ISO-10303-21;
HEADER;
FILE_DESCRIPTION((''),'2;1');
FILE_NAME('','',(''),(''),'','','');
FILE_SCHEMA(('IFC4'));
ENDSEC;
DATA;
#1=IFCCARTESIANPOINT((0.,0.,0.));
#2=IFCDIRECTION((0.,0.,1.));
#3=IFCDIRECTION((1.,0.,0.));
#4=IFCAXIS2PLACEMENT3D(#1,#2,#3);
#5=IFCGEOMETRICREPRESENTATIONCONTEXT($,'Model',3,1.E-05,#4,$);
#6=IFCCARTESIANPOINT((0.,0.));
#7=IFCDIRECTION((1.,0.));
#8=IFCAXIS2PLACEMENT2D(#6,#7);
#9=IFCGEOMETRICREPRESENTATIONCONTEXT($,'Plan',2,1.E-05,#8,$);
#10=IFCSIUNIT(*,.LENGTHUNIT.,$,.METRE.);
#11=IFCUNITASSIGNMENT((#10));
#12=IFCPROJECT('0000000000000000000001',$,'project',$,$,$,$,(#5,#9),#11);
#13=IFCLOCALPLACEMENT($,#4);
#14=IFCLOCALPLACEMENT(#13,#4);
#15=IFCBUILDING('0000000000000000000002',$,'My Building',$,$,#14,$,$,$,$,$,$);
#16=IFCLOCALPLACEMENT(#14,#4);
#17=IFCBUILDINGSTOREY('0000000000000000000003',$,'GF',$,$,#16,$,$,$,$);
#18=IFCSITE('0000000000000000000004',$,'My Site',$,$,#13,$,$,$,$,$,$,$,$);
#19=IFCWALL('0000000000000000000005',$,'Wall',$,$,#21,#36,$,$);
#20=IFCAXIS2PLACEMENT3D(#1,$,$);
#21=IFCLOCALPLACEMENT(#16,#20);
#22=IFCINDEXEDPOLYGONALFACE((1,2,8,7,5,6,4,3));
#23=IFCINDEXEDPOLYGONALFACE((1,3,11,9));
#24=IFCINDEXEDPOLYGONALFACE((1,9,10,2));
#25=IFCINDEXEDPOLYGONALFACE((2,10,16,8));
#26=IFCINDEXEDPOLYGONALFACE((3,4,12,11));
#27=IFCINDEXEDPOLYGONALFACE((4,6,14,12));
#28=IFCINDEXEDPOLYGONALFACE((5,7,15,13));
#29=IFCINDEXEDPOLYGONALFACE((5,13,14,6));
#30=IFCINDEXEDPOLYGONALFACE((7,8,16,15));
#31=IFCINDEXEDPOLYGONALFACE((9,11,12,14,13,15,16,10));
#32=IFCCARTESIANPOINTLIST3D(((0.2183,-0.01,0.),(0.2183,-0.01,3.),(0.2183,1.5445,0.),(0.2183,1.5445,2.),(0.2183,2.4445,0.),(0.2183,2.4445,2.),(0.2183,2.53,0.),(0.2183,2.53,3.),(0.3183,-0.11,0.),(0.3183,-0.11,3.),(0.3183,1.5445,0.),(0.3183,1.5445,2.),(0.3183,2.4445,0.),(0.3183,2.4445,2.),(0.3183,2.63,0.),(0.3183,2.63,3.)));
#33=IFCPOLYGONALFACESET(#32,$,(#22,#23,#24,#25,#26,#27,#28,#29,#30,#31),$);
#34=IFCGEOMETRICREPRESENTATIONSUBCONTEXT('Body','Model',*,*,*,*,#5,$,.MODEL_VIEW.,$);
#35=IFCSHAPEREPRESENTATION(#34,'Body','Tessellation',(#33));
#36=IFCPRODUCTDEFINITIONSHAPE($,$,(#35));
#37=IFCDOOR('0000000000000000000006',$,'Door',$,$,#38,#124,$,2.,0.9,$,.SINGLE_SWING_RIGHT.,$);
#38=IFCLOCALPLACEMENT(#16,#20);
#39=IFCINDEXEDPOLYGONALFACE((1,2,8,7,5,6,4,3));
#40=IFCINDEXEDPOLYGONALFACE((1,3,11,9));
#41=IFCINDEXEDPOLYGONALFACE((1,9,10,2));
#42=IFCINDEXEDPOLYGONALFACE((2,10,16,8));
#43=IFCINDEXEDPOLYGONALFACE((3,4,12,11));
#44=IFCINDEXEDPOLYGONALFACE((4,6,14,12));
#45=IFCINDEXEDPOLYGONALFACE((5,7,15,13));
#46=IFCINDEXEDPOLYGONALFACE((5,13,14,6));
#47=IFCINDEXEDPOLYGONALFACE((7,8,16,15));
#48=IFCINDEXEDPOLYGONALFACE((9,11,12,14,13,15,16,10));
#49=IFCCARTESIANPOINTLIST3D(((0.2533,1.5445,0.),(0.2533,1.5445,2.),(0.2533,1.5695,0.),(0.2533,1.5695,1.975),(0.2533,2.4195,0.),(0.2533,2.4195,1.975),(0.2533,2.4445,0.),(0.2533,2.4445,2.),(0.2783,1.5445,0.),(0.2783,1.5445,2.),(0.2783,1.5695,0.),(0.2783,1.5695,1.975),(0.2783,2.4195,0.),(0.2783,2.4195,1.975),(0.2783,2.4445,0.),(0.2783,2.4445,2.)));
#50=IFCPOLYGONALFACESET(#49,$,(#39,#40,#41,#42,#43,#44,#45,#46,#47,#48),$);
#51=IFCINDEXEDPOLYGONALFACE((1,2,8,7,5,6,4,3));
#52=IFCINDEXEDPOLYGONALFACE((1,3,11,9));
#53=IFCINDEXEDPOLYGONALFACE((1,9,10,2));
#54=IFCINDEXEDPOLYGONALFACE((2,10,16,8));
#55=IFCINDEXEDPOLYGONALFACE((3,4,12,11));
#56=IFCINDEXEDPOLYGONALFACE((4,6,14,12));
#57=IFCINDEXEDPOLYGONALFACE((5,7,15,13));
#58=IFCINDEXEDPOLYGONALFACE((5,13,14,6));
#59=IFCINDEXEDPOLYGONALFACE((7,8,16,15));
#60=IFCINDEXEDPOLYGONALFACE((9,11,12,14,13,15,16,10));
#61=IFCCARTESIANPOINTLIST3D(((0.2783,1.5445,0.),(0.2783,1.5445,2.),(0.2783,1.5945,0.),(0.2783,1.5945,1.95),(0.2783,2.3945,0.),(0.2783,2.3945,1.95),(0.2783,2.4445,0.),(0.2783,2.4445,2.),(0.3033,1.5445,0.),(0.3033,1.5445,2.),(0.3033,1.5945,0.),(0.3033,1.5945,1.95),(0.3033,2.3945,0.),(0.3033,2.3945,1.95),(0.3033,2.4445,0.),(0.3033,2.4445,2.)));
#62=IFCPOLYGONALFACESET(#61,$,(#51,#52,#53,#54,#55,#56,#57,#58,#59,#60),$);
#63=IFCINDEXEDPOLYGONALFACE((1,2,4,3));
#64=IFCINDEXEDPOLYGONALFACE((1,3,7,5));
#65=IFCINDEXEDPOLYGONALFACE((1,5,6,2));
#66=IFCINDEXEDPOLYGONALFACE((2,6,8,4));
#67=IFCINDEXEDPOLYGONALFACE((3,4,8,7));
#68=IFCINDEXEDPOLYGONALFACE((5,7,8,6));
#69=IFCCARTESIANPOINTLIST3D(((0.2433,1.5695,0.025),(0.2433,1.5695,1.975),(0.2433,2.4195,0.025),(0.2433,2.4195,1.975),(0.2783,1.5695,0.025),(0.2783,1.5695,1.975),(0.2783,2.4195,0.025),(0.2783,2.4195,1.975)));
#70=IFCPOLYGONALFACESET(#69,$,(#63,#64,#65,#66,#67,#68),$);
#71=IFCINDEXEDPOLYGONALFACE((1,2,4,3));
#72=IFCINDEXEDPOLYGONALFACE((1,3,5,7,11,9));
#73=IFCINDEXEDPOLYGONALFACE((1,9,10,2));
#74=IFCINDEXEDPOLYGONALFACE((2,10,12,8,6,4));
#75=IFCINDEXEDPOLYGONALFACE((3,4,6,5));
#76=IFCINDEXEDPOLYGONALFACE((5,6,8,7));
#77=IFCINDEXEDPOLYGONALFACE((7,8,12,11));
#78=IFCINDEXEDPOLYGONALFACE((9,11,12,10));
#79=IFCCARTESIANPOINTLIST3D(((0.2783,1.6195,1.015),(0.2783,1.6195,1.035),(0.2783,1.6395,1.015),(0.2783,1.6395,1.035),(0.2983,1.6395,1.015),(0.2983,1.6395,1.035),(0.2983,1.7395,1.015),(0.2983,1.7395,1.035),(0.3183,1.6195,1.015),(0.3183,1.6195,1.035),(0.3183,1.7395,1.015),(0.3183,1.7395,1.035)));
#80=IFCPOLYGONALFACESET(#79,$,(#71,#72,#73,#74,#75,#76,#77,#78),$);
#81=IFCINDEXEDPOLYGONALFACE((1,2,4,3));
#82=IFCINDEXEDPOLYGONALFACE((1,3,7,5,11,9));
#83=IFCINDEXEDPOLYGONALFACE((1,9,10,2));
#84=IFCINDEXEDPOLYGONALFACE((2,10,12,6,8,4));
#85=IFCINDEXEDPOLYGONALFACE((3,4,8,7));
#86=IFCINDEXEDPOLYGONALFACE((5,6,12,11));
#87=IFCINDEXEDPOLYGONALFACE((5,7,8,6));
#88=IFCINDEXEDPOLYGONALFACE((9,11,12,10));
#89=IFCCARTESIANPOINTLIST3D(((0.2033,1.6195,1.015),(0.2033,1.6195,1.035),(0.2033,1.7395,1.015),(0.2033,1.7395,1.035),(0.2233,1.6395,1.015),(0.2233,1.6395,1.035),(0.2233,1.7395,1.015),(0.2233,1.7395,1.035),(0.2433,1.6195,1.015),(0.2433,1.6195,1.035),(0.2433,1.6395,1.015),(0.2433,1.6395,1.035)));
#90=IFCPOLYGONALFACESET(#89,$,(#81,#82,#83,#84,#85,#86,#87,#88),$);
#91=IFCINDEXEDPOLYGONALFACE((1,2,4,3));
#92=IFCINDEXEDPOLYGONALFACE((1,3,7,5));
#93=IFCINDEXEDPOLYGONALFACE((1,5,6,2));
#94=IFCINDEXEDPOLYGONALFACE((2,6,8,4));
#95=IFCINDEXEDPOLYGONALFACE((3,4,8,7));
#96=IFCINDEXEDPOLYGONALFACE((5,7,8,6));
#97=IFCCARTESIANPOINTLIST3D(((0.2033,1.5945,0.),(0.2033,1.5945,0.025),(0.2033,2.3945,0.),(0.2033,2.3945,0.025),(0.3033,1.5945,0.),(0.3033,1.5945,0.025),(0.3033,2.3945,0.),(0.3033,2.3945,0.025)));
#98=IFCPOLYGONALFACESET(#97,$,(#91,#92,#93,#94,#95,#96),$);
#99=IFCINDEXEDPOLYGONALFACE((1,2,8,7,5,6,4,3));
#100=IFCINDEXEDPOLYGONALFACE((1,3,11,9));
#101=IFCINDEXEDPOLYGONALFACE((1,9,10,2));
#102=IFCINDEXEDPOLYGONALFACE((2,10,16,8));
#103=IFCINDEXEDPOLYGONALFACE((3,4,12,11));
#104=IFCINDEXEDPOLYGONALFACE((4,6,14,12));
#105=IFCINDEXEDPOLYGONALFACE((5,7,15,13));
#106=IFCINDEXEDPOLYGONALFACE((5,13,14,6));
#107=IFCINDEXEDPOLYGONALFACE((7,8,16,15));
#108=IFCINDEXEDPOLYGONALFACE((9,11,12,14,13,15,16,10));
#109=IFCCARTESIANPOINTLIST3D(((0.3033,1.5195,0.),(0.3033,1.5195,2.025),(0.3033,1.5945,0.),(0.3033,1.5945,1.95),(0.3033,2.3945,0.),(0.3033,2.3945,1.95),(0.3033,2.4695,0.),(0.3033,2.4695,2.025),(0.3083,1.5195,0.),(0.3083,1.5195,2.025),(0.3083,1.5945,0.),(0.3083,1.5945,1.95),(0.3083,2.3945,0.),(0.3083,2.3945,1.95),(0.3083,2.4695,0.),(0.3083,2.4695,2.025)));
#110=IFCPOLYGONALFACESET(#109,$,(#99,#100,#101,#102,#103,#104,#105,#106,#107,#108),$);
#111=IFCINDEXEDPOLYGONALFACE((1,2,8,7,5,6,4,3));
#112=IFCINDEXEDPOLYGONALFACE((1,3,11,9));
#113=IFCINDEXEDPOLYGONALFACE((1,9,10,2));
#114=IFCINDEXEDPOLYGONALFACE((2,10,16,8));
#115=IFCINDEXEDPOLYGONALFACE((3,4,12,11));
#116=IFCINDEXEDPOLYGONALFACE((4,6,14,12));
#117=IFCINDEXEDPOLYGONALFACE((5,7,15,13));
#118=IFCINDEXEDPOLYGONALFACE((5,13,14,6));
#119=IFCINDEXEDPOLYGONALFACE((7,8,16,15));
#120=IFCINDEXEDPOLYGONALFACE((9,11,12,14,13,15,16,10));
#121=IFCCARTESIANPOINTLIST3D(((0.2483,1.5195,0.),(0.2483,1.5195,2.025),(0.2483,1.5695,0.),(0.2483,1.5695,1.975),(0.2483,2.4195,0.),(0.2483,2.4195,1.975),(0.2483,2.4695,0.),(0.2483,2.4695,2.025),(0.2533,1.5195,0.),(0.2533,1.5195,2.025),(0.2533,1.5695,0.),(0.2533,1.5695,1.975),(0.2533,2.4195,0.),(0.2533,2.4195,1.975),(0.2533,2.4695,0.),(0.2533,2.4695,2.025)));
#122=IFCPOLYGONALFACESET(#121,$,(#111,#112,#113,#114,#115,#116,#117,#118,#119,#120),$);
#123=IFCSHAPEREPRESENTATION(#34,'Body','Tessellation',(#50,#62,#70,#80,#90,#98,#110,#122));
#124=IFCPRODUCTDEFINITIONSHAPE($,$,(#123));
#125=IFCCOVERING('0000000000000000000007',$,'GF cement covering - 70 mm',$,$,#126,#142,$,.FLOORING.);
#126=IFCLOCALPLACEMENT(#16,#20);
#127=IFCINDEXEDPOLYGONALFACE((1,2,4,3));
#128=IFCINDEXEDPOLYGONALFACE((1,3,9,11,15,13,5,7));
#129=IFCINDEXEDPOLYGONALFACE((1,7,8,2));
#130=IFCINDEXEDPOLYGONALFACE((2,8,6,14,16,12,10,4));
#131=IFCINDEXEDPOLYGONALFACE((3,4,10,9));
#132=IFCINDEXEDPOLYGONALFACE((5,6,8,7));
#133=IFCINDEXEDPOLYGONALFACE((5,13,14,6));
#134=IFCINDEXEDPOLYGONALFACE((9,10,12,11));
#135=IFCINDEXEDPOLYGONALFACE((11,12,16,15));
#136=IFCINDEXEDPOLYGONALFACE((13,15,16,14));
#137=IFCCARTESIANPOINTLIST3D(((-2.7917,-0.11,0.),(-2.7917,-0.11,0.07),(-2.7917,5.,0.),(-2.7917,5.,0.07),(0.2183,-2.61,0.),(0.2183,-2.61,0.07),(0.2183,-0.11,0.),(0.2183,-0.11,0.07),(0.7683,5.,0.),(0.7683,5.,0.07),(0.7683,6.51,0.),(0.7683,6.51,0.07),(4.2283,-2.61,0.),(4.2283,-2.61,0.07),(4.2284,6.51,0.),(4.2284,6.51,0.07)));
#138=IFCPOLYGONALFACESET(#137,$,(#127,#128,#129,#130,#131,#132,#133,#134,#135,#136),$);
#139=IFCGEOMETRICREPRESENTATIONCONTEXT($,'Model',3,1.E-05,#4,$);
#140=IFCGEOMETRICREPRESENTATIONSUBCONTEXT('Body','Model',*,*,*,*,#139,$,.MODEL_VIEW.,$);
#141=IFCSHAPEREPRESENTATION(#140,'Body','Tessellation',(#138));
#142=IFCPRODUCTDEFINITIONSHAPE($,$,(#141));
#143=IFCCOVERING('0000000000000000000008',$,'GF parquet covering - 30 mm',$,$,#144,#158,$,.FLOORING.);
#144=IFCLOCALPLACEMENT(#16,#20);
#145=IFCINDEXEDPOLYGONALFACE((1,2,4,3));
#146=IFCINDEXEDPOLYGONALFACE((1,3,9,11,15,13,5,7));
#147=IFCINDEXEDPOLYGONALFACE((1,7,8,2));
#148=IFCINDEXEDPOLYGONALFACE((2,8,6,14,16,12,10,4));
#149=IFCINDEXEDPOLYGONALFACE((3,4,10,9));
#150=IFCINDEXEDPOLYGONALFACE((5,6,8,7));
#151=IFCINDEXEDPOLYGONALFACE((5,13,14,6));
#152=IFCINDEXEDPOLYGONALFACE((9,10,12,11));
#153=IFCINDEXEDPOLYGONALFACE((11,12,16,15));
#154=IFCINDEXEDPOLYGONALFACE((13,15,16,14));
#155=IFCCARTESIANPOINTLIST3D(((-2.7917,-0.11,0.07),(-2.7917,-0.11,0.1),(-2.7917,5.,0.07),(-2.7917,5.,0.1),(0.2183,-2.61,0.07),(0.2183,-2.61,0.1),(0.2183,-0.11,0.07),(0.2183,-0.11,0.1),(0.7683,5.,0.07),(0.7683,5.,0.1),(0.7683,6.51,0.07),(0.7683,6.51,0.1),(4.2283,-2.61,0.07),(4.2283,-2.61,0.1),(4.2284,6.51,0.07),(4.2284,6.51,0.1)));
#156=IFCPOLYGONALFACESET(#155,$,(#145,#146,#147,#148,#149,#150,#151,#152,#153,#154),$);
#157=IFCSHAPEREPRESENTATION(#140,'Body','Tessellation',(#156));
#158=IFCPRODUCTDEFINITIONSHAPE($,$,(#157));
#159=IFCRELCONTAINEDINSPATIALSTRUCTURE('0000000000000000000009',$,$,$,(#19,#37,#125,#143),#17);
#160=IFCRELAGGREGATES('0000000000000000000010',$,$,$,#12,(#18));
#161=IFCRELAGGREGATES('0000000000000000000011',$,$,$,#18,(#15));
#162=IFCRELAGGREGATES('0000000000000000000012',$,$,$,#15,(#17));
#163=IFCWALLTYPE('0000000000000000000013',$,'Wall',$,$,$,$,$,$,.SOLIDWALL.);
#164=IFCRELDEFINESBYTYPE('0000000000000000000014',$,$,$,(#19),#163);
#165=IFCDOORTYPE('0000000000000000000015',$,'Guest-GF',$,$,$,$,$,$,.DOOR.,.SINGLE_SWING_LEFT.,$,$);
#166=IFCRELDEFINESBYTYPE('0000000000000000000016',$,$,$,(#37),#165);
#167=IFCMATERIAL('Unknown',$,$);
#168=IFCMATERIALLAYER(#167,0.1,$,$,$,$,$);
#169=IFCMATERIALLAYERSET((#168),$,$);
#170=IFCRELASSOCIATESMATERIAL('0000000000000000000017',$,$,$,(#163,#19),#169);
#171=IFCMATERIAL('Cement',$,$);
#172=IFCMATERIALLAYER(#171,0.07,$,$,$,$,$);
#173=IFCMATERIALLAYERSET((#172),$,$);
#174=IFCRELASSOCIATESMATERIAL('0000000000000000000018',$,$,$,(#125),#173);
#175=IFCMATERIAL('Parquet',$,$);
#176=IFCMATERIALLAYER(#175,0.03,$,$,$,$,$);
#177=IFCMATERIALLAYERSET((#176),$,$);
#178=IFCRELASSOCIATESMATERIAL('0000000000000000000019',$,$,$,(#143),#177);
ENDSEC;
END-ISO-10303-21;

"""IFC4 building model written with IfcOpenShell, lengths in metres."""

from ifc_helpers import new_model, entity, si_unit, frame, origin_with_axes, origin_2d_with_axis, place, context, subcontext, project, spatial, line, indexed_curve, outline, extrude, shape, source, transform, mapped, material, layer, layer_set, layer_usage, type_object, type_shapes, element, fill, save


model = new_model("IFC4")

# Units and contexts
model_context_1 = context("Model", 3, precision=1e-05, world=origin_with_axes())
plan_context = context("Plan", 2, precision=1e-05, world=origin_2d_with_axis())
model_context_2 = context("Model", 3, precision=1e-05, world=origin_with_axes())
body_context_1 = subcontext(model_context_1, "Body", "Model", "MODEL_VIEW")
body_context_2 = subcontext(plan_context, "Body", "Plan", "PLAN_VIEW")
body_context_3 = subcontext(model_context_2, "Body", "Model", "MODEL_VIEW")
ifc_project = project(units=[si_unit("LENGTHUNIT", "METRE")], contexts=[model_context_1, plan_context])

# Site, building, storey
site_placement = place(None, origin_with_axes())
site = spatial("IfcSite", under=ifc_project, at=site_placement, Name="My Site")
building_placement = place(site_placement, origin_with_axes())
building = spatial("IfcBuilding", under=site, at=building_placement, Name="My Building")
storey_placement = place(building_placement, origin_with_axes())
storey = spatial("IfcBuildingStorey", under=building, at=storey_placement, Name="GF")

# Shared definitions
ifc_material_1 = material(Name="Unknown")

# Shared definitions
ifc_layer_1 = layer(ifc_material_1, 0.1)
ifc_layer_set_1 = layer_set([ifc_layer_1])
wall_type = type_object("IfcWallType", Name="Wall", PredefinedType="SOLIDWALL", material=ifc_layer_set_1)

# Wall, opening, door
ifc_layer_usage_1 = layer_usage(ifc_layer_set_1, "AXIS2", "POSITIVE", 0.0)
wall_1_placement = place(storey_placement, frame((0.3183, -0.11, 0.0), z_axis=(0.0, 0.0, 1.0), x_axis=(0.0, 1.0, 0.0)))
wall_1 = element("IfcWall", 1, at=wall_1_placement, inside=storey, type_object=wall_type, material=ifc_layer_usage_1, Name="Wall", context=body_context_1, shape_type="SweptSolid", body=[
    extrude(outline(indexed_curve([(0.0, 0.0), (0.1, 0.1), (2.64, 0.1), (2.74, 0.0)], segments=[line(1, 2, 3, 4, 1)])), origin_with_axes(), (0.0, 0.0, 1.0), 3.0),
])
shared_shape_1 = source(origin_with_axes(), body_context_1, "Body", "SweptSolid", [
    extrude(outline(indexed_curve([(0.0, 0.0), (0.9, 0.0), (0.9, 2.0), (0.0, 2.0)], segments=[line(1, 2, 3, 4, 1)])), frame((0.0, -0.6, 0.0), z_axis=(0.0, -1.0, 0.0), x_axis=(1.0, 0.0, 0.0)), (0.0, 0.0, -1.0), 1.2),
])
opening_1_placement = place(wall_1_placement, frame((1.6545, 0.015, 0.0), z_axis=(0.0, 0.0, 1.0), x_axis=(1.0, 0.0, 0.0)))
opening_1 = element("IfcOpeningElement", 2, at=opening_1_placement, cuts=wall_1, PredefinedType="OPENING", context=body_context_1, shape_type="MappedRepresentation", body=[
    mapped(shared_shape_1, transform((0.0, 0.0, 0.0), x_axis=(1.0, 0.0, 0.0), y_axis=(0.0, 1.0, 0.0), z_axis=(0.0, 0.0, 1.0), scale=1.0)),
])
door_type_1 = type_object("IfcDoorType", Name="Guest-GF", OperationType="SINGLE_SWING_LEFT", PredefinedType="DOOR")
shared_shape_2 = source(origin_with_axes(), body_context_1, "Body", "SweptSolid", [
    extrude(outline(indexed_curve([(0.0, 0.0), (0.0, 2.0), (0.9, 2.0), (0.9, 0.0), (0.875, 0.0), (0.875, 1.975), (0.025, 1.975), (0.025, 0.0)], segments=[line(1, 2, 3, 4, 5, 6, 7, 8, 1)])), frame((0.0, 0.025, 0.0), z_axis=(0.0, -1.0, 0.0), x_axis=(1.0, 0.0, 0.0)), (0.0, 0.0, -1.0), 0.025),
    extrude(outline(indexed_curve([(0.0, 0.0), (0.0, 2.0), (0.9, 2.0), (0.9, 0.0), (0.85, 0.0), (0.85, 1.95), (0.05, 1.95), (0.05, 0.0)], segments=[line(1, 2, 3, 4, 5, 6, 7, 8, 1)])), frame((0.0, 0.0, 0.0), z_axis=(0.0, -1.0, 0.0), x_axis=(1.0, 0.0, 0.0)), (0.0, 0.0, -1.0), 0.025),
    extrude(outline(indexed_curve([(0.0, 0.0), (0.85, 0.0), (0.85, 0.035), (0.0, 0.035)], segments=[line(1, 2, 3, 4, 1)])), frame((0.025, 0.025, 0.025), z_axis=(0.0, 0.0, 1.0), x_axis=(1.0, 0.0, 0.0)), (0.0, 0.0, 1.0), 1.95),
    extrude(outline(indexed_curve([(0.0, 0.0), (0.0, -0.04), (0.12, -0.04), (0.12, -0.02), (0.02, -0.02), (0.02, 0.0)], segments=[line(1, 2, 3, 4, 5, 6, 1)])), frame((0.075, 0.025, 1.015), z_axis=(0.0, 0.0, 1.0), x_axis=(1.0, 0.0, 0.0)), (0.0, 0.0, 1.0), 0.02),
    extrude(outline(indexed_curve([(0.0, 0.0), (0.0, 0.04), (0.12, 0.04), (0.12, 0.02), (0.02, 0.02), (0.02, 0.0)], segments=[line(1, 2, 3, 4, 5, 6, 1)])), frame((0.075, 0.06, 1.015), z_axis=(0.0, 0.0, 1.0), x_axis=(1.0, 0.0, 0.0)), (0.0, 0.0, 1.0), 0.02),
    extrude(outline(indexed_curve([(0.0, 0.0), (0.8, 0.0), (0.8, 0.1), (0.0, 0.1)], segments=[line(1, 2, 3, 4, 1)])), frame((0.05, 0.0, 0.0), z_axis=(0.0, 0.0, 1.0), x_axis=(1.0, 0.0, 0.0)), (0.0, 0.0, 1.0), 0.025),
    extrude(outline(indexed_curve([(0.0, 0.0), (0.0, 2.025), (0.95, 2.025), (0.95, 0.0), (0.875, 0.0), (0.875, 1.95), (0.075, 1.95), (0.075, 0.0)], segments=[line(1, 2, 3, 4, 5, 6, 7, 8, 1)])), frame((-0.025, -0.005, 0.0), z_axis=(0.0, -1.0, 0.0), x_axis=(1.0, 0.0, 0.0)), (0.0, 0.0, -1.0), 0.005),
    extrude(outline(indexed_curve([(0.0, 0.0), (0.0, 2.025), (0.95, 2.025), (0.95, 0.0), (0.9, 0.0), (0.9, 1.975), (0.05, 1.975), (0.05, 0.0)], segments=[line(1, 2, 3, 4, 5, 6, 7, 8, 1)])), frame((-0.025, 0.05, 0.0), z_axis=(0.0, -1.0, 0.0), x_axis=(1.0, 0.0, 0.0)), (0.0, 0.0, -1.0), 0.005),
])
shared_shape_3 = source(origin_with_axes(), body_context_2, "Body", "Curve2D", [
    entity("IfcIndexedPolyCurve", entity("IfcCartesianPointList2D", [[0.0, 0.0], [0.0, 0.05], [0.025, 0.05], [0.025, 0.025], [0.05, 0.025], [0.05, 0.0]]), [entity("IfcLineIndex", [1, 2, 3, 4, 5, 6, 1])]),
    entity("IfcIndexedPolyCurve", entity("IfcCartesianPointList2D", [[0.9, 0.0], [0.9, 0.05], [0.875, 0.05], [0.875, 0.025], [0.85, 0.025], [0.85, 0.0]]), [entity("IfcLineIndex", [1, 2, 3, 4, 5, 6, 1])]),
    entity("IfcTrimmedCurve", entity("IfcEllipse", entity("IfcAxis2Placement2D", entity("IfcCartesianPoint", [0.84, 0.05]), entity("IfcDirection", [1.0, 0.0])), 0.815, 0.85), [entity("IfcCartesianPoint", [0.84, 0.9])], [entity("IfcCartesianPoint", [0.025, 0.05])], True, "CARTESIAN"),
    entity("IfcIndexedPolyCurve", entity("IfcCartesianPointList2D", [[0.875, 0.05], [0.84, 0.05], [0.84, 0.9], [0.875, 0.9]]), [entity("IfcLineIndex", [1, 2, 3, 4, 1])]),
])
type_shapes(door_type_1, [shared_shape_2, shared_shape_3])
door_1_placement = place(opening_1_placement, frame((0.0, 0.0, 0.0), z_axis=(0.0, 0.0, 1.0), x_axis=(1.0, 0.0, 0.0)))
door_1 = element("IfcDoor", 3, at=door_1_placement, inside=storey, type_object=door_type_1, Name="Door", OperationType="SINGLE_SWING_RIGHT", OverallHeight=2.0, OverallWidth=0.9, shapes=[
    shape(body_context_1, "Body", "MappedRepresentation", [mapped(shared_shape_2, transform((0.0, 0.0, 0.0), x_axis=(1.0, 0.0, 0.0), y_axis=(0.0, 1.0, 0.0), z_axis=(0.0, 0.0, 1.0), scale=1.0))]),
    shape(body_context_2, "Body", "MappedRepresentation", [mapped(shared_shape_3, transform((0.0, 0.0, 0.0), x_axis=(1.0, 0.0, 0.0), y_axis=(0.0, 1.0, 0.0), z_axis=(0.0, 0.0, 1.0), scale=1.0))]),
])
fill(opening_1, door_1)

# Coverings
ifc_material_2 = material(Name="Cement")
ifc_layer_2 = layer(ifc_material_2, 0.07)
ifc_layer_set_2 = layer_set([ifc_layer_2])
placement_1 = place(None, origin_with_axes())
placement_2 = place(placement_1, origin_with_axes())
placement_3 = place(placement_2, origin_with_axes())
placement_4 = place(placement_3, frame((0.2183, -2.61, 0.0), z_axis=(0.0, 0.0, 1.0), x_axis=(1.0, 0.0, 0.0)))
element("IfcCovering", 4, at=placement_4, inside=storey, material=ifc_layer_set_2, Name="GF cement covering - 70 mm", PredefinedType="FLOORING", context=body_context_3, shape_type="SweptSolid", body=[
    extrude(outline(indexed_curve([(4.01, 0.0), (4.01, 9.12), (0.55, 9.12), (0.55, 7.61), (-3.01, 7.61), (-3.01, 2.5), (0.0, 2.5), (0.0, 0.0), (4.01, 0.0)])), origin_with_axes(), (0.0, 0.0, 1.0), 0.07),
])
ifc_material_3 = material(Name="Parquet")
ifc_layer_3 = layer(ifc_material_3, 0.03)
ifc_layer_set_3 = layer_set([ifc_layer_3])
element("IfcCovering", 5, at=placement_4, inside=storey, material=ifc_layer_set_3, Name="GF parquet covering - 30 mm", PredefinedType="FLOORING", context=body_context_3, shape_type="SweptSolid", body=[
    extrude(outline(indexed_curve([(4.01, 0.0), (4.01, 9.12), (0.55, 9.12), (0.55, 7.61), (-3.01, 7.61), (-3.01, 2.5), (0.0, 2.5), (0.0, 0.0), (4.01, 0.0)])), frame((0.0, 0.0, 0.07), z_axis=(0.0, 0.0, 1.0), x_axis=(1.0, 0.0, 0.0)), (0.0, 0.0, 1.0), 0.03),
])

save(model, "model.ifc")
